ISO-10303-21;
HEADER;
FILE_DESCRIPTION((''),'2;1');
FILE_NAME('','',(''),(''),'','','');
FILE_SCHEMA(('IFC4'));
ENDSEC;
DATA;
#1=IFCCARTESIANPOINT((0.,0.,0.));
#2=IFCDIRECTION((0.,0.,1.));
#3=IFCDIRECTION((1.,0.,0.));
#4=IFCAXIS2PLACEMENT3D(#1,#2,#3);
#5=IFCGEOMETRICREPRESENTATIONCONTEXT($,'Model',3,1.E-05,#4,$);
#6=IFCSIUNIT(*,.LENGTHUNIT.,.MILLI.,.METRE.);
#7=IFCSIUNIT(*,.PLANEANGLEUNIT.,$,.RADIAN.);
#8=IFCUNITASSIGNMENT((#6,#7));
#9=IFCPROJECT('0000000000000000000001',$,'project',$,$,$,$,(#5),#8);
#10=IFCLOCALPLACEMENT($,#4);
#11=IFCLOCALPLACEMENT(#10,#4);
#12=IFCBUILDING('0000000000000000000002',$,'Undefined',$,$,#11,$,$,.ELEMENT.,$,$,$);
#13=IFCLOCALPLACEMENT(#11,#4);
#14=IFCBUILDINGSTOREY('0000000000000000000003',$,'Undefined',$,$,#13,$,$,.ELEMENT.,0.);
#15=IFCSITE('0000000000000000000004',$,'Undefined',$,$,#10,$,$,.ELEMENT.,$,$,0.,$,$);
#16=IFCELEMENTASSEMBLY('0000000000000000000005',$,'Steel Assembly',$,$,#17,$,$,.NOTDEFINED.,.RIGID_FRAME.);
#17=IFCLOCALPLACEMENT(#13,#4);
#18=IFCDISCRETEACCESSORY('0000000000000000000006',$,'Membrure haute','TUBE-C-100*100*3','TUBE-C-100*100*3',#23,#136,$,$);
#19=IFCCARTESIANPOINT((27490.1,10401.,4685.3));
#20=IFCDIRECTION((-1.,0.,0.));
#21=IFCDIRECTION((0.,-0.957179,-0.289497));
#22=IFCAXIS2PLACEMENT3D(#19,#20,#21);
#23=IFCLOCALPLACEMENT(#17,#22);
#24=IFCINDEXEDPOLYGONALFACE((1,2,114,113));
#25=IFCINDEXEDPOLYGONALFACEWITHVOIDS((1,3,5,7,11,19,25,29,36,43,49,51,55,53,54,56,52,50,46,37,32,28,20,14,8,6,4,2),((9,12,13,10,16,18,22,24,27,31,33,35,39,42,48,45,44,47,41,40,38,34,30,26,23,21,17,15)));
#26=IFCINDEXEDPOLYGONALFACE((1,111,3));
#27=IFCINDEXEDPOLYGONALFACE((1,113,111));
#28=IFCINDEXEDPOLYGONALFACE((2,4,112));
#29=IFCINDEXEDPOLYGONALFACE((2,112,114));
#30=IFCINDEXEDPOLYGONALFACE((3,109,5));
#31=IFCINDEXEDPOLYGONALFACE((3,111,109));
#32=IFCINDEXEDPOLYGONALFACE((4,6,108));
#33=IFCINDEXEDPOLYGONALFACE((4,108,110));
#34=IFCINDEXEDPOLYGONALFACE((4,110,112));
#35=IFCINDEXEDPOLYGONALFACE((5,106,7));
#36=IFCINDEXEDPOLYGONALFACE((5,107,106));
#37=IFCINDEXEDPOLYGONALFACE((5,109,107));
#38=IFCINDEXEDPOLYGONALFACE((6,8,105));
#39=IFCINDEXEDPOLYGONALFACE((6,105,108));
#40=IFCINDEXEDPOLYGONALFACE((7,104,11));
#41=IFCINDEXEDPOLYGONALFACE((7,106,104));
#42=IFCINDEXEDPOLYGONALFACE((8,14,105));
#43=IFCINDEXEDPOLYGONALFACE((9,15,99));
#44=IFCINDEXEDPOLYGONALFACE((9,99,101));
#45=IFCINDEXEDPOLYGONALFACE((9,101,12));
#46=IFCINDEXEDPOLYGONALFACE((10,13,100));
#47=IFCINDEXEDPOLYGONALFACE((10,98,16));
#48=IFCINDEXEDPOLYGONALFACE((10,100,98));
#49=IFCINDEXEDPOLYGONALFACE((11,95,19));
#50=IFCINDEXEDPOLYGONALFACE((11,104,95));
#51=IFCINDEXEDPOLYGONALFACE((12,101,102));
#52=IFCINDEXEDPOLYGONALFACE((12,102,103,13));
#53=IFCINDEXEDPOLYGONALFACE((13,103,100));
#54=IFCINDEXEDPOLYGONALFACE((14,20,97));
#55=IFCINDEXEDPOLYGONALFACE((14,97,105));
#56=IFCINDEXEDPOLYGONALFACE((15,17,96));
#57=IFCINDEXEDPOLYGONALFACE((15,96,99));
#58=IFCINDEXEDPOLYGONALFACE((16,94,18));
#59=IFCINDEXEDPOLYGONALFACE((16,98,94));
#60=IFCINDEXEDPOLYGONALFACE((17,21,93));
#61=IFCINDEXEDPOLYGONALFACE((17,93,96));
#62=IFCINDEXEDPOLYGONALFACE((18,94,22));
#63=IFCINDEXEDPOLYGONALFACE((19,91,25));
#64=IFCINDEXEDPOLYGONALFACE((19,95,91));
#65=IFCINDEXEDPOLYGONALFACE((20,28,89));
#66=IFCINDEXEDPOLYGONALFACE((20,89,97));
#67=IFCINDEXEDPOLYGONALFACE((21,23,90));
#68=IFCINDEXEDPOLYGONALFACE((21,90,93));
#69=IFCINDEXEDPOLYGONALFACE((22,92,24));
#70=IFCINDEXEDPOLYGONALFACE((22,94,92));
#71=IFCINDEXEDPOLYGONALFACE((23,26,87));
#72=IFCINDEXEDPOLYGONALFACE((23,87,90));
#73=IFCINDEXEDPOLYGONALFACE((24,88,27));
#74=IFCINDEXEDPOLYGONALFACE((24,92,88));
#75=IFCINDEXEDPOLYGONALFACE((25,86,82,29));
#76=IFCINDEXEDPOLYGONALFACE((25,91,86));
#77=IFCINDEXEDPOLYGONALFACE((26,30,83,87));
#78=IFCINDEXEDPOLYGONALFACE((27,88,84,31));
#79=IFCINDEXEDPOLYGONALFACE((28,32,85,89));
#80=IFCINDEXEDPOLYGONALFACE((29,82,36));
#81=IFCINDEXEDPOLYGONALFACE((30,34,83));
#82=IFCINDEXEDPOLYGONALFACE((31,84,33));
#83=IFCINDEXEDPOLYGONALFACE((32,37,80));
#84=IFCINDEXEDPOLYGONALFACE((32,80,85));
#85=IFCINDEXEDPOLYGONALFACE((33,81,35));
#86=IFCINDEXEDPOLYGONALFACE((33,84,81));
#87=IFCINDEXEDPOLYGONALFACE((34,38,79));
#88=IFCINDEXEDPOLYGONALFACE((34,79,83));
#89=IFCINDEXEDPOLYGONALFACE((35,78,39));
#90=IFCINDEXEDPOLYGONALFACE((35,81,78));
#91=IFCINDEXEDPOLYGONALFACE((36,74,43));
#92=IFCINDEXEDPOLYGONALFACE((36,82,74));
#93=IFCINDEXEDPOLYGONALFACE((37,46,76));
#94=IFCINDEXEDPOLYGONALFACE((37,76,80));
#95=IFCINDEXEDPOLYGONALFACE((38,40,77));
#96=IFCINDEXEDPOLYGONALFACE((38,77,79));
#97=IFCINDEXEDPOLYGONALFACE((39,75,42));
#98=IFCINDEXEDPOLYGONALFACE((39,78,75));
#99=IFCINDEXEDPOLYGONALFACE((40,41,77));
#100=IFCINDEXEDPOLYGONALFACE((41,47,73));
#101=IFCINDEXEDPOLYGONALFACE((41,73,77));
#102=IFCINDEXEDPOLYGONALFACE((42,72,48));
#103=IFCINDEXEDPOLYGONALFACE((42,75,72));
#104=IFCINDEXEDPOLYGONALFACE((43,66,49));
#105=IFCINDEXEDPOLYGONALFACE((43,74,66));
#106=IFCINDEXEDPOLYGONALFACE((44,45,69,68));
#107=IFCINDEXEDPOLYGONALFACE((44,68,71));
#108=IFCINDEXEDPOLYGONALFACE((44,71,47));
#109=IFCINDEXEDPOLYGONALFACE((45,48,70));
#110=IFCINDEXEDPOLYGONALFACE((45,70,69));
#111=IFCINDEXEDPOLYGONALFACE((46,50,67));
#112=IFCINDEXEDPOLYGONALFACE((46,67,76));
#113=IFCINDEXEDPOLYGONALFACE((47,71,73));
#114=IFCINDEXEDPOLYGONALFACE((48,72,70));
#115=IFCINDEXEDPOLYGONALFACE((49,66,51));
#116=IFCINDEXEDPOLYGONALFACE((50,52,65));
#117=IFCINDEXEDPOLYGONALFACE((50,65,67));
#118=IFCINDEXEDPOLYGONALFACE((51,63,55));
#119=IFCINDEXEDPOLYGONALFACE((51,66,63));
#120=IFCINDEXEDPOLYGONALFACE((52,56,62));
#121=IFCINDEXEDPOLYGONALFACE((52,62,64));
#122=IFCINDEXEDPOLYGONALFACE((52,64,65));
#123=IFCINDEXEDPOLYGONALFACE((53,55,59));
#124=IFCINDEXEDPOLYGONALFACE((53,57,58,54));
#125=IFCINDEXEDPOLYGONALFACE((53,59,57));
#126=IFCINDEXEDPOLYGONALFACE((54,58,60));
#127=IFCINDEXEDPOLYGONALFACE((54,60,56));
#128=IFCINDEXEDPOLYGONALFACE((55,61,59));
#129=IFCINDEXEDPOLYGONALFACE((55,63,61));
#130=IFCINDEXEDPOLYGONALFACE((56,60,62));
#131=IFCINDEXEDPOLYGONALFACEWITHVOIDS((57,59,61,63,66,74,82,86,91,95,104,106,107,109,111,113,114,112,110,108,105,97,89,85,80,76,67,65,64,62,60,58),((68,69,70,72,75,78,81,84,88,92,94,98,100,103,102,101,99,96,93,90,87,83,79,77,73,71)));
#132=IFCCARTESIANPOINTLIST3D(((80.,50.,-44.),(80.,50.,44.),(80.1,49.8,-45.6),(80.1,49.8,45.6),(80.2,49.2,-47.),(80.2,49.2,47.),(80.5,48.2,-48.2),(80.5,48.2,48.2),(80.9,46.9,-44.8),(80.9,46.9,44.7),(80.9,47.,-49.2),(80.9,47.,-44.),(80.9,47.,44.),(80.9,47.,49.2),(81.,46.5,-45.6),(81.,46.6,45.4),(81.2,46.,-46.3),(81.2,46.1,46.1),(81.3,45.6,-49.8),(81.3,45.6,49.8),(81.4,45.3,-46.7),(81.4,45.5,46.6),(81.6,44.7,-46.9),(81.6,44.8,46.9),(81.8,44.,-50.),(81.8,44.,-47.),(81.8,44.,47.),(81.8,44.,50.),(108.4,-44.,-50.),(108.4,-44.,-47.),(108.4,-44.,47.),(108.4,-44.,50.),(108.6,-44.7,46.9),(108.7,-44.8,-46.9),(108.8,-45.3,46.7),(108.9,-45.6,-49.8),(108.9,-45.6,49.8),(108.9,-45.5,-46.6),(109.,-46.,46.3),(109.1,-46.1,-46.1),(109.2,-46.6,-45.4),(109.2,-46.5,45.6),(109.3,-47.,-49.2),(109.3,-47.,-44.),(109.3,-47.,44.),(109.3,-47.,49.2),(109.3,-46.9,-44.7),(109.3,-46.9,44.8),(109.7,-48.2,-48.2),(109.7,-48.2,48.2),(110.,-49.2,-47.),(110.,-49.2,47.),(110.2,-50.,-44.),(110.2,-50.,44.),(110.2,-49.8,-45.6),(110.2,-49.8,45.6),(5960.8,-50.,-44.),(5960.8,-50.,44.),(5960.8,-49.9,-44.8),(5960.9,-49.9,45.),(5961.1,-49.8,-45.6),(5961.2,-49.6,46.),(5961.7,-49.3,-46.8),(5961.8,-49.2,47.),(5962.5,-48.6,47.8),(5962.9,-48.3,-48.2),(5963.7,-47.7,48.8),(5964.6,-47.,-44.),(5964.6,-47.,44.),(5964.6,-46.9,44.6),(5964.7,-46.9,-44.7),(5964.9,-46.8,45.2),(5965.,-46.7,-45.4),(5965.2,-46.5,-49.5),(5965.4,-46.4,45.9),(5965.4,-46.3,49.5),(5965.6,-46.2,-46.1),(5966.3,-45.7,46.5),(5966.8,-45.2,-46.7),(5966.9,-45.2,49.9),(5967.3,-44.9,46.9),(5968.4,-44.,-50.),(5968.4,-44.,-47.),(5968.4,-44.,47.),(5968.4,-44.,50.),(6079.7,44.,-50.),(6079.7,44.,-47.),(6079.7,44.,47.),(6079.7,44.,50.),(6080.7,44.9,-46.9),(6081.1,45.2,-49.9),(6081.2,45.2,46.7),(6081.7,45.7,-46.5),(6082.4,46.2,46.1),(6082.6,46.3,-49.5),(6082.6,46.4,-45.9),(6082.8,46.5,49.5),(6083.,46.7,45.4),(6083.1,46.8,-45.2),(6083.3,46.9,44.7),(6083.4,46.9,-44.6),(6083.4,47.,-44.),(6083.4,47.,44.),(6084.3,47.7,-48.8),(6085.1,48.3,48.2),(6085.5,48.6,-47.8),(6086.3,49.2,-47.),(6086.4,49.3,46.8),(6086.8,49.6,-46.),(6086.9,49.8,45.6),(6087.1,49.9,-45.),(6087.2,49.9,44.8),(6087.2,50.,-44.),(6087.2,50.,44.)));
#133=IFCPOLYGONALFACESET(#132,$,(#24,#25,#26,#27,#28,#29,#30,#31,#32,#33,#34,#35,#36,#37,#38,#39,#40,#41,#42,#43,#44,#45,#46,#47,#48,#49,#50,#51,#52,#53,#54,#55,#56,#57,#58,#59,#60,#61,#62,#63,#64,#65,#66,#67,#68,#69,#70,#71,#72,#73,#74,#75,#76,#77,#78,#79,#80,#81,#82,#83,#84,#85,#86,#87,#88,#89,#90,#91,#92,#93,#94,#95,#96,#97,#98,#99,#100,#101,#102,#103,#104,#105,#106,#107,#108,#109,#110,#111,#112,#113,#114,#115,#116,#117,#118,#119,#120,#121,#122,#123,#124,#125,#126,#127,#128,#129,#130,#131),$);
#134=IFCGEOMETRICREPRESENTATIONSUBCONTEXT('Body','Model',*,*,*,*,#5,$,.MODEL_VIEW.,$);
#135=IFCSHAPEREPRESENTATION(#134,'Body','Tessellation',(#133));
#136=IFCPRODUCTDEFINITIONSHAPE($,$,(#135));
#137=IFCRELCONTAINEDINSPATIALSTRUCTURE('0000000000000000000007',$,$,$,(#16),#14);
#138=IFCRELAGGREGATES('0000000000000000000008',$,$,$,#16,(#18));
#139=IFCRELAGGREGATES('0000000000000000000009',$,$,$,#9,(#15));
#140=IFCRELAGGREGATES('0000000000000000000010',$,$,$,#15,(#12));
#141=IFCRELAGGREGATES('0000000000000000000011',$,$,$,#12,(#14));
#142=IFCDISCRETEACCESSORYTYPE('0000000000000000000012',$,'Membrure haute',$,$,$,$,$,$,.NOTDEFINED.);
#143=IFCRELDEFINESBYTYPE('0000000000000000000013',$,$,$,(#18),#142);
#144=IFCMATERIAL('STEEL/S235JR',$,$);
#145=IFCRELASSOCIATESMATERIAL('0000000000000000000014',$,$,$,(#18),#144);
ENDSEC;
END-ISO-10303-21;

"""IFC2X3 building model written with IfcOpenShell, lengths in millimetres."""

from ifc_helpers import new_model, si_unit, frame, origin_with_axes, origin_2d_with_axis, place, context, subcontext, project, spatial, hollow_rectangle, extrude, clip, halfspace, material, type_object, element, aggregate, save


model = new_model("IFC2X3")

# Units and contexts
model_context = context("Model", 3, precision=1e-05, world=origin_with_axes())
body_context = subcontext(model_context, "Body", "Model", "MODEL_VIEW")
ifc_project = project(units=[si_unit("LENGTHUNIT", "METRE", prefix="MILLI"), si_unit("PLANEANGLEUNIT", "RADIAN")], contexts=[model_context])

# Site, building, storey
site_placement = place(None, origin_with_axes())
site = spatial("IfcSite", under=ifc_project, at=site_placement, Name="Undefined", CompositionType="ELEMENT", RefElevation=0.0)
building_placement = place(site_placement, origin_with_axes())
building = spatial("IfcBuilding", under=site, at=building_placement, Name="Undefined", CompositionType="ELEMENT")
storey_placement = place(building_placement, origin_with_axes())
storey = spatial("IfcBuildingStorey", under=building, at=storey_placement, Name="Undefined", CompositionType="ELEMENT", Elevation=0.0)

# Element assembly
assembly_1_placement = place(storey_placement, origin_with_axes())
assembly_1 = element("IfcElementAssembly", 1, at=assembly_1_placement, inside=storey, Name="Steel Assembly", AssemblyPlace="NOTDEFINED", PredefinedType="RIGID_FRAME")
ifc_material_1 = material(Name="STEEL/S235JR")

# Discrete accessory
discrete_accessory_type_1 = type_object("IfcDiscreteAccessoryType", Name="Membrure haute")
discrete_accessory_1_placement = place(assembly_1_placement, frame((27490.1, 10401.0, 4685.3), z_axis=(-1.0, 0.0, 0.0), x_axis=(0.0, -0.957179, -0.289497)))
discrete_accessory_1 = element("IfcDiscreteAccessory", 2, at=discrete_accessory_1_placement, type_object=discrete_accessory_type_1, material=ifc_material_1, Name="Membrure haute", Description="TUBE-C-100*100*3", ObjectType="TUBE-C-100*100*3", context=body_context, shape_type="Clipping", body=[
    clip(clip(extrude(hollow_rectangle(XDim=100.0, YDim=100.0, WallThickness=3.0, InnerFilletRadius=3.0, OuterFilletRadius=6.0, at=origin_2d_with_axis()), frame((6120.4, 0.0, 0.0), z_axis=(-1.0, 0.0, 0.0), x_axis=(0.0, -1.0, 0.0)), (0.0, 0.0, 1.0), 6121.7), halfspace(frame((5960.8, -50.0, -50.0), z_axis=(-0.620241, 0.784411, 0.0), x_axis=(0.0, 0.0, -1.0)), True)), halfspace(frame((64.4, 101.5, 0.0), z_axis=(-0.957179, -0.289497, 0.0), x_axis=(0.289497, -0.957179, 0.0)), False)),
])
aggregate(assembly_1, [discrete_accessory_1])

save(model, "model.ifc")
